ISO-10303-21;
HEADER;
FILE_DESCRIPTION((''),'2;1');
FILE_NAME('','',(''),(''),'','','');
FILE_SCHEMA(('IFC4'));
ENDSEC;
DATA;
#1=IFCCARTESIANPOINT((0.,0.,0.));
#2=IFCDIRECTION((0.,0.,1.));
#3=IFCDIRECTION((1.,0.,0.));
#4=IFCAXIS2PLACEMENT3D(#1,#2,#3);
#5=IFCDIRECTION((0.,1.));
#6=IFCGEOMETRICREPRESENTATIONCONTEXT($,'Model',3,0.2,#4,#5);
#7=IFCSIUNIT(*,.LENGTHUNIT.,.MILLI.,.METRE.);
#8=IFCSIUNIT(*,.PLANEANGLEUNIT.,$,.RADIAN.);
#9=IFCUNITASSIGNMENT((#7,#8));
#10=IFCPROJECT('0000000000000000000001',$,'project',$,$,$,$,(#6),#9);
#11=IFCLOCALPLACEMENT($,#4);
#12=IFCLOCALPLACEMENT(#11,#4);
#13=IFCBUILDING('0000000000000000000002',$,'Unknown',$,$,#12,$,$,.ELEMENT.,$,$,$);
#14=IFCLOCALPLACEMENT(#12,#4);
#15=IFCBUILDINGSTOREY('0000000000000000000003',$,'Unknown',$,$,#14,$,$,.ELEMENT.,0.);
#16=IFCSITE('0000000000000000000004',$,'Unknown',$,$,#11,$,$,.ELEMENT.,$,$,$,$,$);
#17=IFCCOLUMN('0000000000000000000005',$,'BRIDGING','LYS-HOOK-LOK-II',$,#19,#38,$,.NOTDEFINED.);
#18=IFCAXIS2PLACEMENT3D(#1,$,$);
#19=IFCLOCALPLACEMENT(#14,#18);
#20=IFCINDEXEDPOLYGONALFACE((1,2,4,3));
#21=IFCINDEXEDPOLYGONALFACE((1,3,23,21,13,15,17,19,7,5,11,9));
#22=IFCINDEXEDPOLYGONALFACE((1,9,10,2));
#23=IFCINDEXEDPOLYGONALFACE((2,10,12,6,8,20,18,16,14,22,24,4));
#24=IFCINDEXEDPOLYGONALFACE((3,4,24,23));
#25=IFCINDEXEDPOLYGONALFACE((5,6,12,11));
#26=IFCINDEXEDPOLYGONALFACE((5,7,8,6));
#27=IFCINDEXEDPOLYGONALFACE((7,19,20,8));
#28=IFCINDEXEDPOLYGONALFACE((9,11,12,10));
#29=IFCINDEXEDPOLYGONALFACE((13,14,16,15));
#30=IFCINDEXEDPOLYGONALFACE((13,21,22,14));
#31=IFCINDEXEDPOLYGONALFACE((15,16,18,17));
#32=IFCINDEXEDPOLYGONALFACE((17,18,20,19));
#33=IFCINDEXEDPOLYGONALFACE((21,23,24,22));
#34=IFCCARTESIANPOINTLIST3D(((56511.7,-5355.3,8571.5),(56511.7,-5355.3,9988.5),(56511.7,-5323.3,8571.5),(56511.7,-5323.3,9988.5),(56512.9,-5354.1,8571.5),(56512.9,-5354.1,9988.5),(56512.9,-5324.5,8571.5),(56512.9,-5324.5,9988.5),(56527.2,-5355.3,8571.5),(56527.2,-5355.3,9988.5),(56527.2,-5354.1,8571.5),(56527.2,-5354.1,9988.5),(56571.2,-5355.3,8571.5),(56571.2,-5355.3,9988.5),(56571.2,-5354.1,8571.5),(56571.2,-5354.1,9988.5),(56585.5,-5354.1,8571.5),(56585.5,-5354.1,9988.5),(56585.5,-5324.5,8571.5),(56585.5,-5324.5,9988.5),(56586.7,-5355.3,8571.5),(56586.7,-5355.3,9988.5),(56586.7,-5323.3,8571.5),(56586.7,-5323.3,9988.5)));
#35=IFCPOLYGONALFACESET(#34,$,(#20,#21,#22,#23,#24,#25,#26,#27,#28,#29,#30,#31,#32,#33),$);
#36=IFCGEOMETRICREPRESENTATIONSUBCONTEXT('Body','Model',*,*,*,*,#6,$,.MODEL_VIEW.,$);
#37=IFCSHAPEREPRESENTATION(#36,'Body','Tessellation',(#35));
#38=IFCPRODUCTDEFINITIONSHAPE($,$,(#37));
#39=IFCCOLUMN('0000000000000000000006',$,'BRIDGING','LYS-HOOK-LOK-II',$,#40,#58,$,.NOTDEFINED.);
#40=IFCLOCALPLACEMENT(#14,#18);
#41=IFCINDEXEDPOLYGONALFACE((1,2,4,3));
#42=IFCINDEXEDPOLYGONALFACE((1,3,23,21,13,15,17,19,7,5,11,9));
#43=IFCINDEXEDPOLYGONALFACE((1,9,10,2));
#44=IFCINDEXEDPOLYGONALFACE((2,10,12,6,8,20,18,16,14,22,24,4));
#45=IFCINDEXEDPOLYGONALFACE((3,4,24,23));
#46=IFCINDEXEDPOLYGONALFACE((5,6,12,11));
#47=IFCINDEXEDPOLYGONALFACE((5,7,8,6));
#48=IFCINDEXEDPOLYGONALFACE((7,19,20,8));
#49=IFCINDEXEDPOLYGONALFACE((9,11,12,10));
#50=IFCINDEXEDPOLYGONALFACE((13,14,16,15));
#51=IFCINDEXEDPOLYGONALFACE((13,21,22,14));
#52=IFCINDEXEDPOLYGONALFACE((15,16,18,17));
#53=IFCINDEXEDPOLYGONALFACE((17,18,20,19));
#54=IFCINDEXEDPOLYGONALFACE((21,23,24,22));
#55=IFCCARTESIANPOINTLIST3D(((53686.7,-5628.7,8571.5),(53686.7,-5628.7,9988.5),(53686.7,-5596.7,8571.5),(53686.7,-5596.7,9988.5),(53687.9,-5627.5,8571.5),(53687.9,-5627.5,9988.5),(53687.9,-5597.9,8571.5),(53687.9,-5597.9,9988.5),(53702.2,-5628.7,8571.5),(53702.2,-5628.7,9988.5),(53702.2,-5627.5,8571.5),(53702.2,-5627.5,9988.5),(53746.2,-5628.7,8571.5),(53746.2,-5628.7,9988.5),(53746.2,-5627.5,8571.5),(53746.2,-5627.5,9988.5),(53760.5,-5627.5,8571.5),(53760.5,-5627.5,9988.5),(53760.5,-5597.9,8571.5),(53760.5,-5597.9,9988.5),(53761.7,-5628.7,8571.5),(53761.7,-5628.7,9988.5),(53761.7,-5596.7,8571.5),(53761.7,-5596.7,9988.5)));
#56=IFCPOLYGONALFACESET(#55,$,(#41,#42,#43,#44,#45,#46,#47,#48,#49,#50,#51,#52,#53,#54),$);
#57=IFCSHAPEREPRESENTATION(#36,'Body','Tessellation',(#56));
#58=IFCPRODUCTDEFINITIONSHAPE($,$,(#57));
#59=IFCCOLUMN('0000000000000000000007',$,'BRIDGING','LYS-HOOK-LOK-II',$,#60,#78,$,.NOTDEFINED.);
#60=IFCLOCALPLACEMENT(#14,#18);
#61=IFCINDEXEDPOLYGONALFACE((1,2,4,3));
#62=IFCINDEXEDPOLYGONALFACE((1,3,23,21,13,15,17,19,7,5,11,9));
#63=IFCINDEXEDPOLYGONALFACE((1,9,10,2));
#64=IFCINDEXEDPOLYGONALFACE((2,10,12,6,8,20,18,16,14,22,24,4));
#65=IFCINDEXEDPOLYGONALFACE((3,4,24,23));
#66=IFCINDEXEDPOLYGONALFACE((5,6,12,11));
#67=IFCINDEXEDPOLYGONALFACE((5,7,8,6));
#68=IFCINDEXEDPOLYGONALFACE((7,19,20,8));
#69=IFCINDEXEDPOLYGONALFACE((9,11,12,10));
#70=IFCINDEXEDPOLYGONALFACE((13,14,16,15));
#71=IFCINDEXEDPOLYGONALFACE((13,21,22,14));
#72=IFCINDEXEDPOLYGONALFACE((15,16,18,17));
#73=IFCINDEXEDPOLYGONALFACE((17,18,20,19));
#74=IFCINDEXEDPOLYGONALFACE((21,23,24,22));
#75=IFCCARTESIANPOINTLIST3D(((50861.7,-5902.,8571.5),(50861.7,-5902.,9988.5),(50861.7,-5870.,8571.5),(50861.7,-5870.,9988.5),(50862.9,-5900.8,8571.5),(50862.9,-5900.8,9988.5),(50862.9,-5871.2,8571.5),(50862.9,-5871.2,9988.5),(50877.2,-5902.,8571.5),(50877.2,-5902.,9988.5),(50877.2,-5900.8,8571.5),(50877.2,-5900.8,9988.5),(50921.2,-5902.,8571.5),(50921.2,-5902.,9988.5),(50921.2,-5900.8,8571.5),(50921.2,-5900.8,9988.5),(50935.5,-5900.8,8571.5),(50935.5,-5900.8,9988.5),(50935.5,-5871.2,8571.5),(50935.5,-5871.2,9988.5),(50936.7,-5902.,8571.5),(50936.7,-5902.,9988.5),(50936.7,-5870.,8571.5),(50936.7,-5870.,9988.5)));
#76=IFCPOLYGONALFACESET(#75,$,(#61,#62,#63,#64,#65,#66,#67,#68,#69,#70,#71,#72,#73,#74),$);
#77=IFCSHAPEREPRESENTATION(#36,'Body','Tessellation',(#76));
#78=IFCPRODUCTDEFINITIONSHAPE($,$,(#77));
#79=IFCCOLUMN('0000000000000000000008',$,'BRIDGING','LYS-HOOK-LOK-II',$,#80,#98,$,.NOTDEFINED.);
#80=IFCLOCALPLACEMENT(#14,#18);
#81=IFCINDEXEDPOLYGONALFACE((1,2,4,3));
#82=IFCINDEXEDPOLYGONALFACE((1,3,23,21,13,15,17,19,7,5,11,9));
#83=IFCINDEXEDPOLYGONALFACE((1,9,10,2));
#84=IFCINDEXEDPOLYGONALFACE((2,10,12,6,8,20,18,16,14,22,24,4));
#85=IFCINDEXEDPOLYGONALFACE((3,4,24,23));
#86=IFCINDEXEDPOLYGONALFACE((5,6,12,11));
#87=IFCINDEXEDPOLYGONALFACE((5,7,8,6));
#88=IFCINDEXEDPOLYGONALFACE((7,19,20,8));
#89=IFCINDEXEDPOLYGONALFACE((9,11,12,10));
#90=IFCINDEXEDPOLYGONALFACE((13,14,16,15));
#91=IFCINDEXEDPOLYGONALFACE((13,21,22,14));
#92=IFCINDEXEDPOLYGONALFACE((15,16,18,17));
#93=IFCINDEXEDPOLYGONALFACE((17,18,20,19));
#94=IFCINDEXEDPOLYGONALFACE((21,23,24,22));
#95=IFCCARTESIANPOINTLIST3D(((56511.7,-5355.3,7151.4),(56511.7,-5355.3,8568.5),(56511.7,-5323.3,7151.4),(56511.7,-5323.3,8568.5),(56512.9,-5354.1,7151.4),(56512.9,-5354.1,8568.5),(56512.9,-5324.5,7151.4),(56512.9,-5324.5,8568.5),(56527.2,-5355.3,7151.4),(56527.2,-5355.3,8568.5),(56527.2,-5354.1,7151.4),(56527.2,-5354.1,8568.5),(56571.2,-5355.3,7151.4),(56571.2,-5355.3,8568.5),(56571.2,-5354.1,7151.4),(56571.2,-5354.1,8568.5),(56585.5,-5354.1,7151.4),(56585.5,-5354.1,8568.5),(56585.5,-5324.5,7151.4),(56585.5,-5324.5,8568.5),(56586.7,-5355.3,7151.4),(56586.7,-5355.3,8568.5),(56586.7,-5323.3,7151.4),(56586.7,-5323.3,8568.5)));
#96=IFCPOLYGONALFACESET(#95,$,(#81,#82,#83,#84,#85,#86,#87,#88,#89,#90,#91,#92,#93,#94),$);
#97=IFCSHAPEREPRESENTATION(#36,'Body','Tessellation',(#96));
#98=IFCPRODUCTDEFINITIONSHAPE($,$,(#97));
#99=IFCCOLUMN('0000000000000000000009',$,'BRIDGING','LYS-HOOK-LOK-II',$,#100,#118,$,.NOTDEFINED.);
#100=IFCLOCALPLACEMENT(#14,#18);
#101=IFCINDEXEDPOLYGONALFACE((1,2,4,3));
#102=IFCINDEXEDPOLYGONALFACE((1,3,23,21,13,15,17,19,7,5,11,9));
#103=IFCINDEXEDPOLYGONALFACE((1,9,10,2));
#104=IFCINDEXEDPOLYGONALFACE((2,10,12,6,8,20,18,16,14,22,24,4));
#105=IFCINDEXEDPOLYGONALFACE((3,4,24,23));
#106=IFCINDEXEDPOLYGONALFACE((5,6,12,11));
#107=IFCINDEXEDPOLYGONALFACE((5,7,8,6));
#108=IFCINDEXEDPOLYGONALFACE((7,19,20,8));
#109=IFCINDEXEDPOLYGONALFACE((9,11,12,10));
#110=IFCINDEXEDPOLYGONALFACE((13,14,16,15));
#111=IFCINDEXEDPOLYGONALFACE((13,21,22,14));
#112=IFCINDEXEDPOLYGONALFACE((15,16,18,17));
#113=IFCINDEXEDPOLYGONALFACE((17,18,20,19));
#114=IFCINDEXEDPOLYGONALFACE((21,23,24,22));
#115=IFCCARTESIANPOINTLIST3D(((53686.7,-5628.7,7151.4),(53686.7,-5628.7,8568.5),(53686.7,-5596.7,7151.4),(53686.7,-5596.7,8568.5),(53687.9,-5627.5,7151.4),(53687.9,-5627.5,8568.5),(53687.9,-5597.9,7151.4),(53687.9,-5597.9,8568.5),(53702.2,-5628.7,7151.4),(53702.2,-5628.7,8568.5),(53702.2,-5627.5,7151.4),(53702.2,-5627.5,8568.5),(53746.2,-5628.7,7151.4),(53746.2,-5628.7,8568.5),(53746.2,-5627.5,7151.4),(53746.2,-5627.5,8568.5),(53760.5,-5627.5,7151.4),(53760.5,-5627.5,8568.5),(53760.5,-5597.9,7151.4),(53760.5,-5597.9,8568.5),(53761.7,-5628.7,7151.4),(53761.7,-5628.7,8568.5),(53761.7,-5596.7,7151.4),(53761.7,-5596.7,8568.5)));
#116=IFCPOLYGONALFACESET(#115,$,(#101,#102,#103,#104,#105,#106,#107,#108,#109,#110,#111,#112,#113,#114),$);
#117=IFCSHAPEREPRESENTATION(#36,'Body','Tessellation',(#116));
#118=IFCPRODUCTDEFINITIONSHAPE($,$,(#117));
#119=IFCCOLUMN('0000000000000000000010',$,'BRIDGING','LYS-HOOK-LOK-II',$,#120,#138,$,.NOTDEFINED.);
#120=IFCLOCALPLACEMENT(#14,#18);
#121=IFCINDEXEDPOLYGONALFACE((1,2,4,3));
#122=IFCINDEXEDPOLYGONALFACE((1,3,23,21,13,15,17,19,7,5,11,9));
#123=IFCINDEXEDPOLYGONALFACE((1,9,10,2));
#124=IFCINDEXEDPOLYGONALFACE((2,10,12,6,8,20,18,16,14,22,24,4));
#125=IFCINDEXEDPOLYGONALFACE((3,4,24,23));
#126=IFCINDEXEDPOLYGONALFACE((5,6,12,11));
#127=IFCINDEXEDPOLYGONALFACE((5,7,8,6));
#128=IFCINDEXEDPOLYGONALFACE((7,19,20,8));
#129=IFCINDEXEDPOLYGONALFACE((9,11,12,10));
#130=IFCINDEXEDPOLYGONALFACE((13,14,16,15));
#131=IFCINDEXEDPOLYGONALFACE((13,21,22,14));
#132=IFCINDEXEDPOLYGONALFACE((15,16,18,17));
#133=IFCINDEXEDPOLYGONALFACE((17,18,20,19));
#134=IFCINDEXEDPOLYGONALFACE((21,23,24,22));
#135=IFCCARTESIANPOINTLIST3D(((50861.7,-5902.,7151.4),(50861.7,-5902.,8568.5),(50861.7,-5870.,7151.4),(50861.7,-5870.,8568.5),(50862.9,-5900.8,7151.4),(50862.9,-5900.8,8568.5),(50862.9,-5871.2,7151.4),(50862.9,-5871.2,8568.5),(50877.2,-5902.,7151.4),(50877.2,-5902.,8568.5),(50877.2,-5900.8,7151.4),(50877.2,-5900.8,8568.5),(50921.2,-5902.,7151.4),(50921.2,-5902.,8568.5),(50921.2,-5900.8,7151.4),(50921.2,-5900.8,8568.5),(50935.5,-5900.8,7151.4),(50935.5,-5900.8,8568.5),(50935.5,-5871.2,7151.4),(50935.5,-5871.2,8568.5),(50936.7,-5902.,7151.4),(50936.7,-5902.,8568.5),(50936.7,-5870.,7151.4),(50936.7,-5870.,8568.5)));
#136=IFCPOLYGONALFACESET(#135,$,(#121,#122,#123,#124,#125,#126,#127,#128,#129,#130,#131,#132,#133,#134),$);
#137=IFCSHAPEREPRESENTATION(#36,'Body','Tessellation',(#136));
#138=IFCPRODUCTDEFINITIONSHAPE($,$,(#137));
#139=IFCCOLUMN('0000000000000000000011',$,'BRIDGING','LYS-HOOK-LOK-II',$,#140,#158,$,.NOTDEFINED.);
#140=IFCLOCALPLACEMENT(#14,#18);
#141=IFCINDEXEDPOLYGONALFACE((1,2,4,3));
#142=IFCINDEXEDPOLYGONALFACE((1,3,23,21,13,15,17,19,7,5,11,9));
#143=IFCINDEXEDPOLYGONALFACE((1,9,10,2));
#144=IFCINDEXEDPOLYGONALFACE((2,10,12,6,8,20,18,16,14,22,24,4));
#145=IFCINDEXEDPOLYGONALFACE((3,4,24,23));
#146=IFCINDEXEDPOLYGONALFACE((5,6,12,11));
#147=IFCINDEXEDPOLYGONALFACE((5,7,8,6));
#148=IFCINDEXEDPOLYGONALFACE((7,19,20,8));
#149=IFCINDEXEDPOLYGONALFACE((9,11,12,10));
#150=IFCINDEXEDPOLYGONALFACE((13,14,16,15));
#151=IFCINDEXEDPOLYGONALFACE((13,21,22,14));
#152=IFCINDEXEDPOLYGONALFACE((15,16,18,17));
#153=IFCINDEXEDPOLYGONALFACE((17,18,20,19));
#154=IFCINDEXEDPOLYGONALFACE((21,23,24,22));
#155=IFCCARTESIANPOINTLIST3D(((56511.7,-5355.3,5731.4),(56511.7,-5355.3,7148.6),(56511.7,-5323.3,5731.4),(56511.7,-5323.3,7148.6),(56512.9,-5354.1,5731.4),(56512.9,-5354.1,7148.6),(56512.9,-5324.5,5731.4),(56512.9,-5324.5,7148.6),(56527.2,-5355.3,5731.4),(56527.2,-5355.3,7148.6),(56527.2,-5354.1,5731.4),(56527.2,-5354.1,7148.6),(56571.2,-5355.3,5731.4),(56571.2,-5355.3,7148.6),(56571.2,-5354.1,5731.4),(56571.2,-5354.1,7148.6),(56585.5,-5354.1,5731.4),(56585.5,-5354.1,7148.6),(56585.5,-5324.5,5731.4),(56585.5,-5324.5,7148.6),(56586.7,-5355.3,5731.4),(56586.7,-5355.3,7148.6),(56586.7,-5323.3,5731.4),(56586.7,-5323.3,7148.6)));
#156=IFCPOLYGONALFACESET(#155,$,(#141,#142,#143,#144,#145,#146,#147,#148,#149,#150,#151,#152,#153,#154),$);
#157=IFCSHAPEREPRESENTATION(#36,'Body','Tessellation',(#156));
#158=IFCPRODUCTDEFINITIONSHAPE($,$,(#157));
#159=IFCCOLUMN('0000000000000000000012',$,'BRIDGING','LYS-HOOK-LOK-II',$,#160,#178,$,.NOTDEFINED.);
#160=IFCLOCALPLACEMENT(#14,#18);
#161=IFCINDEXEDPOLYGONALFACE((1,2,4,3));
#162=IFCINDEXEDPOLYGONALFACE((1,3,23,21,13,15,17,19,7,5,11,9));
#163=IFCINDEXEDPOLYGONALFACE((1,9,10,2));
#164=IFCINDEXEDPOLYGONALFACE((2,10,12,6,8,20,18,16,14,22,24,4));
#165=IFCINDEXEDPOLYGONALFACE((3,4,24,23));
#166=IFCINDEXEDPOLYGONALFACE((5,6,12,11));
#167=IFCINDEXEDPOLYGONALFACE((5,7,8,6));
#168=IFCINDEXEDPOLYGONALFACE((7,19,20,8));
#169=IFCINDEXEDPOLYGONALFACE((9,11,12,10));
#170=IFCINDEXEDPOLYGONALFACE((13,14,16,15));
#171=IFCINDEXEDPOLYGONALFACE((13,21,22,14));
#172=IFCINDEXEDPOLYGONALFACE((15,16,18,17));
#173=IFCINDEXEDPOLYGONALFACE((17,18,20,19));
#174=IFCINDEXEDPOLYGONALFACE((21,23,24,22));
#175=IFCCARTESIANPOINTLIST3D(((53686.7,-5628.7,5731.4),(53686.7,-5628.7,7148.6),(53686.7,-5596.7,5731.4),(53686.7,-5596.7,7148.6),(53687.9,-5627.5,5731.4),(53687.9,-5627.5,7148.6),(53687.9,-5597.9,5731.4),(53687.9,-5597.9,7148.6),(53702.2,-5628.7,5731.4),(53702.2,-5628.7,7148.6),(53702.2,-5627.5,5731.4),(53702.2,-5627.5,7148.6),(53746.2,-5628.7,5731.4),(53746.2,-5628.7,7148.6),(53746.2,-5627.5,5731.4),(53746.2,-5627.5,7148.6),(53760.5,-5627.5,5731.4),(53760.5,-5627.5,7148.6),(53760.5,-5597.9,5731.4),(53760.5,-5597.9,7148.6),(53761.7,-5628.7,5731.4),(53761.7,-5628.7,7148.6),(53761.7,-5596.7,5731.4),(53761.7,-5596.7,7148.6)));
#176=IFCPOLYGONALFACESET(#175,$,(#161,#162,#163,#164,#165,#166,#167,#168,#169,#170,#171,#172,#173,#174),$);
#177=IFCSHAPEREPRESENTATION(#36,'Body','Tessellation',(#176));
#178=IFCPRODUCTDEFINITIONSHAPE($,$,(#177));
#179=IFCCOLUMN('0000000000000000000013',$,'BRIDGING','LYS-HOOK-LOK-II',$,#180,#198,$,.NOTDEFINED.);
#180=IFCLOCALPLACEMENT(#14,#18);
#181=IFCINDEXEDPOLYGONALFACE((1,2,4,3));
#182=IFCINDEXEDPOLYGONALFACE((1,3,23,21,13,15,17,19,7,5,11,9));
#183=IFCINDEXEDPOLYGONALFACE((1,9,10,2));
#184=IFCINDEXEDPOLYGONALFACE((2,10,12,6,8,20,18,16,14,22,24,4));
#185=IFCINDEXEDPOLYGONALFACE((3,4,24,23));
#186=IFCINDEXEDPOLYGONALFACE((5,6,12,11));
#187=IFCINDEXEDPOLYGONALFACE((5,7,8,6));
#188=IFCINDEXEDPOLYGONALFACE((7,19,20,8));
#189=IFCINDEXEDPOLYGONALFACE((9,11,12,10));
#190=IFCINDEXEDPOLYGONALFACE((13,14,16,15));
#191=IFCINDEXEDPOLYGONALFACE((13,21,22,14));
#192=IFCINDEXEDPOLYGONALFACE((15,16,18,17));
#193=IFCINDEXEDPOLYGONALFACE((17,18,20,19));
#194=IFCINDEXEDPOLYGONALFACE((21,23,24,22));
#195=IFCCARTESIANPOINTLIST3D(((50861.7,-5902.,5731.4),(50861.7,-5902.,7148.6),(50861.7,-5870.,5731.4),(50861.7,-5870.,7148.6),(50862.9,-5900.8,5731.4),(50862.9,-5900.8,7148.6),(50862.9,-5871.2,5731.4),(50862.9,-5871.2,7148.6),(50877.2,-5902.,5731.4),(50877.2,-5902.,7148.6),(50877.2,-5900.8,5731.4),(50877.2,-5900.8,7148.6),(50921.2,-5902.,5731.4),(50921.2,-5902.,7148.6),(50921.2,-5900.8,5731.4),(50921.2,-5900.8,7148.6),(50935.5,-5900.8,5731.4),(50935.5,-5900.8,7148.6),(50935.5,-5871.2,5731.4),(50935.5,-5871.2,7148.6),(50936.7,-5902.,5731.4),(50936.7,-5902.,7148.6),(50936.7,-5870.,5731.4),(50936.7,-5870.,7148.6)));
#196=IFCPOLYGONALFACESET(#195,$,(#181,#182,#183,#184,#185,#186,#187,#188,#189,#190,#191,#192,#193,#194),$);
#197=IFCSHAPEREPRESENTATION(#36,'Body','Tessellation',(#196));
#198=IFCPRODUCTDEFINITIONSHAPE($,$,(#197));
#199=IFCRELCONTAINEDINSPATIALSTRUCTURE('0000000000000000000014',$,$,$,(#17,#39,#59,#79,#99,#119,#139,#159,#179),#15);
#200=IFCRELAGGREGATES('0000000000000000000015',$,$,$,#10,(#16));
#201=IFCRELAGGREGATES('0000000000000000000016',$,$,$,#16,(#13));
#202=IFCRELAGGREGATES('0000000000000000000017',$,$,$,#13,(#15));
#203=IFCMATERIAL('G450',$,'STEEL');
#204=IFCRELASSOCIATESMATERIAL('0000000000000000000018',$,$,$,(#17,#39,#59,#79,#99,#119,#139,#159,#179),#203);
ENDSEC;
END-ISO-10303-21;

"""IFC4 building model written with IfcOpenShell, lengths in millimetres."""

from ifc_helpers import new_model, si_unit, direction, frame, origin_with_axes, place, context, subcontext, project, spatial, line, indexed_curve, outline, extrude, material, element, save


model = new_model("IFC4")

# Units and contexts
model_context = context("Model", 3, precision=0.2, world=origin_with_axes(), true_north=direction((0.0, 1.0)))
body_context = subcontext(model_context, "Body", "Model", "MODEL_VIEW")
ifc_project = project(units=[si_unit("LENGTHUNIT", "METRE", prefix="MILLI"), si_unit("PLANEANGLEUNIT", "RADIAN")], contexts=[model_context])

# Site, building, storey
site_placement = place(None, origin_with_axes())
site = spatial("IfcSite", under=ifc_project, at=site_placement, Name="Unknown", CompositionType="ELEMENT")
building_placement = place(site_placement, origin_with_axes())
building = spatial("IfcBuilding", under=site, at=building_placement, Name="Unknown", CompositionType="ELEMENT")
storey_placement = place(building_placement, origin_with_axes())
storey = spatial("IfcBuildingStorey", under=building, at=storey_placement, Name="Unknown", CompositionType="ELEMENT", Elevation=0.0)

# Columns
ifc_material_1 = material(Name="G450", Category="STEEL")
for number, where, z_axis, x_axis, name in (
    (1, (56549.2, -5339.3, 8571.5), (0.0, -1.0, 0.0), (0.0, 0.0, 1.0), "BRIDGING"),
    (2, (53724.2, -5612.7, 8571.5), (0.0, -1.0, 0.0), (0.0, 0.0, 1.0), "BRIDGING"),
    (3, (50899.2, -5886.0, 8571.5), (0.0, -1.0, 0.0), (0.0, 0.0, 1.0), "BRIDGING"),
):
    element("IfcColumn", number, at=place(storey_placement, frame(where, z_axis=z_axis, x_axis=x_axis)), inside=storey, material=ifc_material_1, Name=name, Description="LYS-HOOK-LOK-II", PredefinedType="NOTDEFINED", context=body_context, shape_type="SolidModel", body=[
        extrude(outline(indexed_curve([(16.0, -37.5), (16.0, -22.0), (14.8, -22.0), (14.8, -36.3), (-14.8, -36.3), (-14.8, 36.3), (14.8, 36.3), (14.8, 22.0), (16.0, 22.0), (16.0, 37.5), (-16.0, 37.5), (-16.0, -37.5)], segments=[line(1, 2, 3, 4, 5, 6, 7, 8, 9, 10, 11, 12, 1)])), frame((0.0, 0.0, 0.0), z_axis=(-1.0, 0.0, 0.0), x_axis=(0.0, 0.0, 1.0)), (0.0, 0.0, -1.0), 1417.0),
    ])
for number, where, z_axis, x_axis, name in (
    (4, (56549.2, -5339.3, 7151.4), (0.0, -1.0, 0.0), (0.0, 0.0, 1.0), "BRIDGING"),
    (5, (53724.2, -5612.7, 7151.4), (0.0, -1.0, 0.0), (0.0, 0.0, 1.0), "BRIDGING"),
    (6, (50899.2, -5886.0, 7151.4), (0.0, -1.0, 0.0), (0.0, 0.0, 1.0), "BRIDGING"),
):
    element("IfcColumn", number, at=place(storey_placement, frame(where, z_axis=z_axis, x_axis=x_axis)), inside=storey, material=ifc_material_1, Name=name, Description="LYS-HOOK-LOK-II", PredefinedType="NOTDEFINED", context=body_context, shape_type="SolidModel", body=[
        extrude(outline(indexed_curve([(16.0, -37.5), (16.0, -22.0), (14.8, -22.0), (14.8, -36.3), (-14.8, -36.3), (-14.8, 36.3), (14.8, 36.3), (14.8, 22.0), (16.0, 22.0), (16.0, 37.5), (-16.0, 37.5), (-16.0, -37.5)], segments=[line(1, 2, 3, 4, 5, 6, 7, 8, 9, 10, 11, 12, 1)])), frame((0.0, 0.0, 0.0), z_axis=(-1.0, 0.0, 0.0), x_axis=(0.0, 0.0, 1.0)), (0.0, 0.0, -1.0), 1417.1),
    ])
for number, where, z_axis, x_axis, name in (
    (7, (56549.2, -5339.3, 5731.4), (0.0, -1.0, 0.0), (0.0, 0.0, 1.0), "BRIDGING"),
    (8, (53724.2, -5612.7, 5731.4), (0.0, -1.0, 0.0), (0.0, 0.0, 1.0), "BRIDGING"),
    (9, (50899.2, -5886.0, 5731.4), (0.0, -1.0, 0.0), (0.0, 0.0, 1.0), "BRIDGING"),
):
    element("IfcColumn", number, at=place(storey_placement, frame(where, z_axis=z_axis, x_axis=x_axis)), inside=storey, material=ifc_material_1, Name=name, Description="LYS-HOOK-LOK-II", PredefinedType="NOTDEFINED", context=body_context, shape_type="SolidModel", body=[
        extrude(outline(indexed_curve([(16.0, -37.5), (16.0, -22.0), (14.8, -22.0), (14.8, -36.3), (-14.8, -36.3), (-14.8, 36.3), (14.8, 36.3), (14.8, 22.0), (16.0, 22.0), (16.0, 37.5), (-16.0, 37.5), (-16.0, -37.5)], segments=[line(1, 2, 3, 4, 5, 6, 7, 8, 9, 10, 11, 12, 1)])), frame((0.0, 0.0, 0.0), z_axis=(-1.0, 0.0, 0.0), x_axis=(0.0, 0.0, 1.0)), (0.0, 0.0, -1.0), 1417.2),
    ])

save(model, "model.ifc")
